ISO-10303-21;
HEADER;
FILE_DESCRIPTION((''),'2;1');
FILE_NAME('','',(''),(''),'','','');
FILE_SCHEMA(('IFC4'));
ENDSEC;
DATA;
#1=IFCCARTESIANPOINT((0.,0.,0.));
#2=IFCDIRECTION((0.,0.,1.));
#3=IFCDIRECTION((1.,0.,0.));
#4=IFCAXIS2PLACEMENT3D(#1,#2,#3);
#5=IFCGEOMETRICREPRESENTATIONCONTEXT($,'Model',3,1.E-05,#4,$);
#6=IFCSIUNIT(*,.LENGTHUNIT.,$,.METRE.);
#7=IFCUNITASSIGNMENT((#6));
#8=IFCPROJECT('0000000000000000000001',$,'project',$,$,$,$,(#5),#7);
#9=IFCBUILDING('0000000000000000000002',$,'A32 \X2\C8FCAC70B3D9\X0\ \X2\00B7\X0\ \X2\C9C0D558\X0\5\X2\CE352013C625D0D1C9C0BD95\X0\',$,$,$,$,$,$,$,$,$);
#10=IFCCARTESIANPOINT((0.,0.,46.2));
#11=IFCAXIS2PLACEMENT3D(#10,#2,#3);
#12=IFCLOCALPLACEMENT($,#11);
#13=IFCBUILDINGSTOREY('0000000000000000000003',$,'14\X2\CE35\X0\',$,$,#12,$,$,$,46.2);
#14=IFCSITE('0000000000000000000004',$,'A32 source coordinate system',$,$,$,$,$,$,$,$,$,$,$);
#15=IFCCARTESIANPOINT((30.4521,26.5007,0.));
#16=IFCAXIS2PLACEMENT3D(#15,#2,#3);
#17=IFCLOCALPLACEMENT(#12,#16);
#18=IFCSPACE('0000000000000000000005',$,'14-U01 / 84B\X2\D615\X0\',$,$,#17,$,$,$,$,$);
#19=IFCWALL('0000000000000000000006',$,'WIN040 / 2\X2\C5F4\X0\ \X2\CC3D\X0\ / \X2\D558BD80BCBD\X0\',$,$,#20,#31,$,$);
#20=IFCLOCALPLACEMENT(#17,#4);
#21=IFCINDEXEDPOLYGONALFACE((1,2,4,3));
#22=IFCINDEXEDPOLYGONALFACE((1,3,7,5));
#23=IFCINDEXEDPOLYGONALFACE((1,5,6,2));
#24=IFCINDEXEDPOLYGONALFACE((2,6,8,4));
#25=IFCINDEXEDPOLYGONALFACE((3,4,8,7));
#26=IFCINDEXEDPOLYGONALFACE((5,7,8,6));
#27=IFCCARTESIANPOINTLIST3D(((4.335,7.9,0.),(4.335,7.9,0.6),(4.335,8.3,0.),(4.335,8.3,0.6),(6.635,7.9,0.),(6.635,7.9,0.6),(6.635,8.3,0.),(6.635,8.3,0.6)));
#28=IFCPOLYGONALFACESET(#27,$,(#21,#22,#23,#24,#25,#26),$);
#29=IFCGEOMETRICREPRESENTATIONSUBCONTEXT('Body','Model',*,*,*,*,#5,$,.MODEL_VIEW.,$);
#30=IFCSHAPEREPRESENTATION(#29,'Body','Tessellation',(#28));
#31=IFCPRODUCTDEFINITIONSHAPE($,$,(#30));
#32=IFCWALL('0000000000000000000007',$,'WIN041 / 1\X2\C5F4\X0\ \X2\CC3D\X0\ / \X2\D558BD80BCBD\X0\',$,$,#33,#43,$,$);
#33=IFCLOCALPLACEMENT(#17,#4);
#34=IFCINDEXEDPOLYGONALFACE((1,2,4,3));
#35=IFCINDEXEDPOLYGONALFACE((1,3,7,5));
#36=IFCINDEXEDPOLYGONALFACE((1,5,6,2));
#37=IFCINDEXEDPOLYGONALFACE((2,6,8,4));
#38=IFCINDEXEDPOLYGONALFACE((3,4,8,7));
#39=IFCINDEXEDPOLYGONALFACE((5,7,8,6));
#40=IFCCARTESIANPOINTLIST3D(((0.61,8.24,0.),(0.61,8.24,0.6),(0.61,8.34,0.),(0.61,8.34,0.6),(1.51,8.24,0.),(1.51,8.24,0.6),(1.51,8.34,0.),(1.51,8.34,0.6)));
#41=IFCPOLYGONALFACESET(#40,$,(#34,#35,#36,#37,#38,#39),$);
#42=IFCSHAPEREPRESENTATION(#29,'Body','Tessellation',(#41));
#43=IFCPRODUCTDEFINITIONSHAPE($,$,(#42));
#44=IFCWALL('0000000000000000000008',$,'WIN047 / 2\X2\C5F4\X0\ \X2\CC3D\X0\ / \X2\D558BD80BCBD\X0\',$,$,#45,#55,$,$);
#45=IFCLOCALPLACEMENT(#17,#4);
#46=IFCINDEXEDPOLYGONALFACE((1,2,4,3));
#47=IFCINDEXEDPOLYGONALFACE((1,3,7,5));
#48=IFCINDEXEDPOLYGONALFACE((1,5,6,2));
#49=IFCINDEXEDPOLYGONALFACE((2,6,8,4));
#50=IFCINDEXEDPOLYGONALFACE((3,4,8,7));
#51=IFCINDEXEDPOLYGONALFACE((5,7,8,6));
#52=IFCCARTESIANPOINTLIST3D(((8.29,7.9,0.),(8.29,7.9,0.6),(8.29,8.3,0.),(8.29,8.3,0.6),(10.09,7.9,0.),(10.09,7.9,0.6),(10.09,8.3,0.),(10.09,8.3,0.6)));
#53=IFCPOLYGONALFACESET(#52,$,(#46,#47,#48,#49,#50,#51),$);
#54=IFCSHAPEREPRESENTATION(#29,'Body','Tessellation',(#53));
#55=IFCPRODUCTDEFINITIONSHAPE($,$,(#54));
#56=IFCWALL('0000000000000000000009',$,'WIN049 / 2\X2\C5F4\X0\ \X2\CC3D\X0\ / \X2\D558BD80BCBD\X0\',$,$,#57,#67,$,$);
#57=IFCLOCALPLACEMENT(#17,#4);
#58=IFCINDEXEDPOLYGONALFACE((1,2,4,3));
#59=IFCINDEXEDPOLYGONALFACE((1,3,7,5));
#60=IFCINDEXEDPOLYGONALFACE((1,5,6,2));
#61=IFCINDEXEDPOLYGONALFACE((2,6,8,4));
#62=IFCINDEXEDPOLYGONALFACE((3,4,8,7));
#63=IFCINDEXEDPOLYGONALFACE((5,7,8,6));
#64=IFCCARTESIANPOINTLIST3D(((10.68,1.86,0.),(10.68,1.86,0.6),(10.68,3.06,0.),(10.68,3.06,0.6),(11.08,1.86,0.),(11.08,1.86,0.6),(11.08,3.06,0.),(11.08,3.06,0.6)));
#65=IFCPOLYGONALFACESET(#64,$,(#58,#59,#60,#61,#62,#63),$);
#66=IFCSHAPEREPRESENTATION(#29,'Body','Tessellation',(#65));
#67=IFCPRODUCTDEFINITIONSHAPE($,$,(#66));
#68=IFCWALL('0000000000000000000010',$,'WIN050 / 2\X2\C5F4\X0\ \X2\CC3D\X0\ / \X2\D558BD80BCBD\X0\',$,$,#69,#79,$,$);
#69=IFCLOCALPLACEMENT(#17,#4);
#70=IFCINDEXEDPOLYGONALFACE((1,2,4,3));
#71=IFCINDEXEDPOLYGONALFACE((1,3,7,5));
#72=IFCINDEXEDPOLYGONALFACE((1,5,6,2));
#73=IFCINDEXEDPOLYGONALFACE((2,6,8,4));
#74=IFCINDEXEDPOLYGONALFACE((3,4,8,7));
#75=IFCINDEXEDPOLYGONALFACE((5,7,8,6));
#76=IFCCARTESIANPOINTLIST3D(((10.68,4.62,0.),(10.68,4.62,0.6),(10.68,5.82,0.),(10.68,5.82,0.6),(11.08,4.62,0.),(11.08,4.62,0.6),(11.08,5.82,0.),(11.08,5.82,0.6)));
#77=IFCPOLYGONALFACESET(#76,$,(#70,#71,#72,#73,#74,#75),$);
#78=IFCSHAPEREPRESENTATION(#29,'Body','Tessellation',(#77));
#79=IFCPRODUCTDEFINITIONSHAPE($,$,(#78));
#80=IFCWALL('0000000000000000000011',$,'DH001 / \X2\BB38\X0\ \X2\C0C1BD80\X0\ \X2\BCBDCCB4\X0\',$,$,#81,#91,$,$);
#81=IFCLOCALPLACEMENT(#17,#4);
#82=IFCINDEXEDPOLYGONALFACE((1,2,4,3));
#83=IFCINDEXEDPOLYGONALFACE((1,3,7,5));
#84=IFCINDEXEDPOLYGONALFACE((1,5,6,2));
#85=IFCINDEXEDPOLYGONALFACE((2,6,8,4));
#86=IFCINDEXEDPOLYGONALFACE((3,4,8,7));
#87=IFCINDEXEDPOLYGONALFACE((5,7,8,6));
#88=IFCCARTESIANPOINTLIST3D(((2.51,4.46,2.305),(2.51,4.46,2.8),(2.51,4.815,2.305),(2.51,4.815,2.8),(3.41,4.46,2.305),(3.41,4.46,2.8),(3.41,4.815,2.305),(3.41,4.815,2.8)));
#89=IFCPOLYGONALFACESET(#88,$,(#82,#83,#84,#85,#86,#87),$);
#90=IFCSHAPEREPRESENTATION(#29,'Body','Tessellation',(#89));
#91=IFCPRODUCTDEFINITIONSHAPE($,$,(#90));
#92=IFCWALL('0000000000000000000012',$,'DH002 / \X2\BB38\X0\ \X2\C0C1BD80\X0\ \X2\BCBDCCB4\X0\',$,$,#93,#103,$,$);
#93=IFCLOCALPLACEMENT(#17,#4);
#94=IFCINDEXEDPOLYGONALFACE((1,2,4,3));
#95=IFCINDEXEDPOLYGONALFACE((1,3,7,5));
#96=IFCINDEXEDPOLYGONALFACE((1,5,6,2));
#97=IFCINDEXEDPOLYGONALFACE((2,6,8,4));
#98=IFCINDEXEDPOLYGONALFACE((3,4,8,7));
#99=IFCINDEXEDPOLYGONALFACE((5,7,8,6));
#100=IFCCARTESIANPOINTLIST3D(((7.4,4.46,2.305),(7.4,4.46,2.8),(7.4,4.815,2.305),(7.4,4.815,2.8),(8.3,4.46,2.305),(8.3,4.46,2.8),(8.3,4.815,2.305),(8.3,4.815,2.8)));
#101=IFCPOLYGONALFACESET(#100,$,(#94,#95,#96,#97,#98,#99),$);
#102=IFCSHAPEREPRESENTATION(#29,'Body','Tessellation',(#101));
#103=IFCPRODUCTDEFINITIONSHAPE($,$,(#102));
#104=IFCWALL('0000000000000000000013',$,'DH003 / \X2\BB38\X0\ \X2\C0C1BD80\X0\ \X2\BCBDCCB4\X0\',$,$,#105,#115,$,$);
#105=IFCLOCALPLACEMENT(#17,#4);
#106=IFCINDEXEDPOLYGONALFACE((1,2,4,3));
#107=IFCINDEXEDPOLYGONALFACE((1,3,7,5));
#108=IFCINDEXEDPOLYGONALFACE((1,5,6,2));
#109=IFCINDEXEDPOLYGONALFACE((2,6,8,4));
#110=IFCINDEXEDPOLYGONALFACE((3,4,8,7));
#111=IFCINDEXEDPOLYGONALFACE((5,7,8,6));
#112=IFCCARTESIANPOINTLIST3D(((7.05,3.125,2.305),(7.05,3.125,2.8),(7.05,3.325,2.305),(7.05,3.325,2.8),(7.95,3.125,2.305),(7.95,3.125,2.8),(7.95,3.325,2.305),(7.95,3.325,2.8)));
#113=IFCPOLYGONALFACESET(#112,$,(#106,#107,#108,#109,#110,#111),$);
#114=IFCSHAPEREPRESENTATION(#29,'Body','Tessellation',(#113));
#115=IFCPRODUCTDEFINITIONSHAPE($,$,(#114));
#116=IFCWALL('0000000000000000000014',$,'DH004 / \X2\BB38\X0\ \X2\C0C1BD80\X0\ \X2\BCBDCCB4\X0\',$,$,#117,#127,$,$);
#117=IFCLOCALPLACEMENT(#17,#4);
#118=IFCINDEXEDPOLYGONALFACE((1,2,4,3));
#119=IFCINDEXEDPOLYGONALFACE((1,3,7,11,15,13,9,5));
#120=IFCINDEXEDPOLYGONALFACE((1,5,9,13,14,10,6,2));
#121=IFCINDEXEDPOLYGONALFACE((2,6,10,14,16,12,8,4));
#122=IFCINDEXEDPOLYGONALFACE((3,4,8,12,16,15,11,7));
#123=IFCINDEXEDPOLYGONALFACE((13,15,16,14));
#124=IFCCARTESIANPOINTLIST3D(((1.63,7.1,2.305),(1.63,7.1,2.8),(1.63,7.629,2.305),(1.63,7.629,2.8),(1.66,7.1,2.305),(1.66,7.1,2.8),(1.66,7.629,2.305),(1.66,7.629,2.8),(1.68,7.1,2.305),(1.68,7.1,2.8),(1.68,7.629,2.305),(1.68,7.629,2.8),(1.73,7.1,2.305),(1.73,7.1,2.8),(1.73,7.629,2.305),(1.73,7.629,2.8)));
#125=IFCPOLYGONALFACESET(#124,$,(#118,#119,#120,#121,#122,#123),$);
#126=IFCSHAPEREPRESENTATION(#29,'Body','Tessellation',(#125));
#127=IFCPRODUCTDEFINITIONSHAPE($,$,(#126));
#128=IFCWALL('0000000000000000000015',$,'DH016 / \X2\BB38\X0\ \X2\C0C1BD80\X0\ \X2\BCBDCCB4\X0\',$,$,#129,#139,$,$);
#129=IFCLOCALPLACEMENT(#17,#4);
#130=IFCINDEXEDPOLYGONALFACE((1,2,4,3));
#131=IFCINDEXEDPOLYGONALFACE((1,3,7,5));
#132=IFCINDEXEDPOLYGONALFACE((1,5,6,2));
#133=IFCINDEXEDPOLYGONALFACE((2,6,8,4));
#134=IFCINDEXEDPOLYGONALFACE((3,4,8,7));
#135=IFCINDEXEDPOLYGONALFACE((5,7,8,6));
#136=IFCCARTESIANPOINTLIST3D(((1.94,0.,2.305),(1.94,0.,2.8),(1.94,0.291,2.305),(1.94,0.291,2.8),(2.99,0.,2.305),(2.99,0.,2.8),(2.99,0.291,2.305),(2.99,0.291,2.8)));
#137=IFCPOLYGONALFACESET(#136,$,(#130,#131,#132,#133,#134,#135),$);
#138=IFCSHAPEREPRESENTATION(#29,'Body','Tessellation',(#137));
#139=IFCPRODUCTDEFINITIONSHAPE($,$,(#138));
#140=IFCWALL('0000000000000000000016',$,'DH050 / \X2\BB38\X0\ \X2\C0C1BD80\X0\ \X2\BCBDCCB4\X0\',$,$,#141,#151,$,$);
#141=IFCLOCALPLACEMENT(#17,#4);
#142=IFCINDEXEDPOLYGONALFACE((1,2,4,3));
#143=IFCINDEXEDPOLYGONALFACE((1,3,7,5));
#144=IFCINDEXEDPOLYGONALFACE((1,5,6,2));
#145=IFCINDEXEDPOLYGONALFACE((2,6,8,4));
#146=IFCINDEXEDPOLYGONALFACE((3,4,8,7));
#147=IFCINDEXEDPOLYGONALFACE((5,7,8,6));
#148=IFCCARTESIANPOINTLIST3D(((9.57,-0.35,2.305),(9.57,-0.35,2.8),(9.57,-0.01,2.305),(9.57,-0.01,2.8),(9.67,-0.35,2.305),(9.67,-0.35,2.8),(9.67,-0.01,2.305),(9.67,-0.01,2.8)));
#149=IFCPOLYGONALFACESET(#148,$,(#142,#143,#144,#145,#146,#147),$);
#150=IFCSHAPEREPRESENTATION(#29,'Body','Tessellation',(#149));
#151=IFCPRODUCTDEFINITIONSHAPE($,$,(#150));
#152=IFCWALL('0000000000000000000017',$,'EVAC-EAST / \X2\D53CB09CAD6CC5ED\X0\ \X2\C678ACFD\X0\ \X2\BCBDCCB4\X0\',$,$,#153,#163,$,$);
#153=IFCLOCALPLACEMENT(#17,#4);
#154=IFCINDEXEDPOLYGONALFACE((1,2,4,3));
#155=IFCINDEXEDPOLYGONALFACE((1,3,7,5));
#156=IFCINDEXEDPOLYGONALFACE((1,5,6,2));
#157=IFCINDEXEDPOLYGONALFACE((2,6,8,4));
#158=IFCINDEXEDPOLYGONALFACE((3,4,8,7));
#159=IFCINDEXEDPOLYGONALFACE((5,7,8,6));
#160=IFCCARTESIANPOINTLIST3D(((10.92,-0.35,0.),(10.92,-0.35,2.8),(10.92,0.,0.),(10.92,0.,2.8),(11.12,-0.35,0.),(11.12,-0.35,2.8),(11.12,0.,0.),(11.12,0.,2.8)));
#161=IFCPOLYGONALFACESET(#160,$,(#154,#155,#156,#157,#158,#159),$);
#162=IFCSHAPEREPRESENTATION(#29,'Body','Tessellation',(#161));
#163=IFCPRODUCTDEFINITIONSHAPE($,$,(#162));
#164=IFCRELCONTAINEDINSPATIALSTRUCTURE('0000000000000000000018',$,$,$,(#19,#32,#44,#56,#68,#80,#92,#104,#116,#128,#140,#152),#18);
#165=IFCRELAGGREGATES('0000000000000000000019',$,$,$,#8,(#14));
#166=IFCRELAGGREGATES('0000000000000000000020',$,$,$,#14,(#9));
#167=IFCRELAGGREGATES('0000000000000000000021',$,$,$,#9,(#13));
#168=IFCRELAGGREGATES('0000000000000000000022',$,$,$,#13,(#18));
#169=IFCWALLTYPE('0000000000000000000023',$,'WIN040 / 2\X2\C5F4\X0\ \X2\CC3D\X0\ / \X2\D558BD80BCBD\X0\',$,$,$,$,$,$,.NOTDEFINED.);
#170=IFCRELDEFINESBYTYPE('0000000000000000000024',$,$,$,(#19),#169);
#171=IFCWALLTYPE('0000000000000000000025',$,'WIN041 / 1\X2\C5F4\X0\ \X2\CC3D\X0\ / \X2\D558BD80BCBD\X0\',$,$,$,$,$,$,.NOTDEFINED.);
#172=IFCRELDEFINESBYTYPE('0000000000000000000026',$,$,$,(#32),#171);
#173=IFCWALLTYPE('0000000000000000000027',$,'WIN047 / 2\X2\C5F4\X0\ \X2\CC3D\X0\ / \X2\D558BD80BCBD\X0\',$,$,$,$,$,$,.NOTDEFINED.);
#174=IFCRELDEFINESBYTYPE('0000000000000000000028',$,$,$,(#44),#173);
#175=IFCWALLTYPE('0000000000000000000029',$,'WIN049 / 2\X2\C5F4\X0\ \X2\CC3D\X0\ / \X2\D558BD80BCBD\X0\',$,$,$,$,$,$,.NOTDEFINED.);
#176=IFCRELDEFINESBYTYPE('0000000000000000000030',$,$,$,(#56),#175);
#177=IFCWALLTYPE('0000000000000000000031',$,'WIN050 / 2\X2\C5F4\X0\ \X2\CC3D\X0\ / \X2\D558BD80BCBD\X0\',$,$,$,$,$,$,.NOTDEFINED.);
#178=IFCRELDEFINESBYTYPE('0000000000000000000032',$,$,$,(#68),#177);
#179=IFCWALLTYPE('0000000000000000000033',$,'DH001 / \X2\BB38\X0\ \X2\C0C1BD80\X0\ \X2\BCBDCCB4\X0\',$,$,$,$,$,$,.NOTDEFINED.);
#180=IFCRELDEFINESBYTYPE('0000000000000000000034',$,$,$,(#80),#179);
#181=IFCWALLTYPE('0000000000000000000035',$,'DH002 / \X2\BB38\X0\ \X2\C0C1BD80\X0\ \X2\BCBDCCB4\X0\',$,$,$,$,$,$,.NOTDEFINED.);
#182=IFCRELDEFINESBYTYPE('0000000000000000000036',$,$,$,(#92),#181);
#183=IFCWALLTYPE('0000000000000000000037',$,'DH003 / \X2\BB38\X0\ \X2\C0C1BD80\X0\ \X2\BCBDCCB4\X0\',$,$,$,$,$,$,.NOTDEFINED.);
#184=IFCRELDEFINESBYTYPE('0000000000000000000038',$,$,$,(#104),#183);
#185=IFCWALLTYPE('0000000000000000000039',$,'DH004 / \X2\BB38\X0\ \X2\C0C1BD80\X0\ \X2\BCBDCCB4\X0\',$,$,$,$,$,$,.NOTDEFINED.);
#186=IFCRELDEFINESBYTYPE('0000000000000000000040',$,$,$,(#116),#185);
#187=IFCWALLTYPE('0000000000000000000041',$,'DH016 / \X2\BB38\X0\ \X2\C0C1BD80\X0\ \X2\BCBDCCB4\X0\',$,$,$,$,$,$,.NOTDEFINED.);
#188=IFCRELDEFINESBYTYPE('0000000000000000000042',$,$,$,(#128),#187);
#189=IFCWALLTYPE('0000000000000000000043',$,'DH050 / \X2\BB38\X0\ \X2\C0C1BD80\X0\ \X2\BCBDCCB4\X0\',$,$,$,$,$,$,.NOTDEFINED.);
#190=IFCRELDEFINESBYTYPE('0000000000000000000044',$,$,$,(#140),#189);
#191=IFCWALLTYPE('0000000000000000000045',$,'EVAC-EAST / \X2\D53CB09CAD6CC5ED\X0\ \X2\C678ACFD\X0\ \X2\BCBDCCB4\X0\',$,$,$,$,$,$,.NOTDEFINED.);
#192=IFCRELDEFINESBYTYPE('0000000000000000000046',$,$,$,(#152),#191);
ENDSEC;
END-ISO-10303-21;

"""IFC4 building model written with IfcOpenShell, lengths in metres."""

from ifc_helpers import new_model, si_unit, frame, origin, origin_with_axes, place, context, subcontext, project, spatial, polyline, outline, extrude, source, transform, mapped, type_object, type_shapes, element, save


model = new_model("IFC4")

# Units and contexts
model_context = context("Model", 3, precision=1e-05, world=origin_with_axes())
body_context = subcontext(model_context, "Body", "Model", "MODEL_VIEW")
ifc_project = project(units=[si_unit("LENGTHUNIT", "METRE")], contexts=[model_context])

# Site, building, storey, space
site = spatial("IfcSite", under=ifc_project, Name="A32 source coordinate system")
building = spatial("IfcBuilding", under=site, Name="A32 주거동 · 지하5층–옥탑지붕")
storey_placement = place(None, frame((0.0, 0.0, 46.2), z_axis=(0.0, 0.0, 1.0), x_axis=(1.0, 0.0, 0.0)))
storey = spatial("IfcBuildingStorey", under=building, at=storey_placement, Name="14층", Elevation=46.2)
space_placement = place(storey_placement, frame((30.4521, 26.5007, 0.0), z_axis=(0.0, 0.0, 1.0), x_axis=(1.0, 0.0, 0.0)))
space = spatial("IfcSpace", under=storey, at=space_placement, Name="14-U01 / 84B형")

# Walls
wall_type_1 = type_object("IfcWallType", Name="WIN040 / 2열 창 / 하부벽", PredefinedType="NOTDEFINED")
shared_shape_1 = source(origin(), body_context, "Body", "SweptSolid", [
    extrude(outline(polyline([(4.335, 8.3), (6.635, 8.3), (6.635, 7.9), (4.335, 7.9), (4.335, 8.3)])), origin(), (0.0, 0.0, 1.0), 0.6),
])
type_shapes(wall_type_1, [shared_shape_1])
wall_1_placement = place(space_placement, origin_with_axes())
element("IfcWall", 1, at=wall_1_placement, inside=space, type_object=wall_type_1, Name="WIN040 / 2열 창 / 하부벽", context=body_context, shape_type="MappedRepresentation", body=[
    mapped(shared_shape_1, transform((0.0, 0.0, 0.0), scale=1.0)),
])
wall_type_2 = type_object("IfcWallType", Name="WIN041 / 1열 창 / 하부벽", PredefinedType="NOTDEFINED")
shared_shape_2 = source(origin(), body_context, "Body", "SweptSolid", [
    extrude(outline(polyline([(0.61, 8.34), (1.51, 8.34), (1.51, 8.24), (0.61, 8.24), (0.61, 8.34)])), origin(), (0.0, 0.0, 1.0), 0.6),
])
type_shapes(wall_type_2, [shared_shape_2])
wall_2_placement = place(space_placement, origin_with_axes())
element("IfcWall", 2, at=wall_2_placement, inside=space, type_object=wall_type_2, Name="WIN041 / 1열 창 / 하부벽", context=body_context, shape_type="MappedRepresentation", body=[
    mapped(shared_shape_2, transform((0.0, 0.0, 0.0), scale=1.0)),
])
wall_type_3 = type_object("IfcWallType", Name="WIN047 / 2열 창 / 하부벽", PredefinedType="NOTDEFINED")
shared_shape_3 = source(origin(), body_context, "Body", "SweptSolid", [
    extrude(outline(polyline([(8.29, 8.3), (10.09, 8.3), (10.09, 7.9), (8.29, 7.9), (8.29, 8.3)])), origin(), (0.0, 0.0, 1.0), 0.6),
])
type_shapes(wall_type_3, [shared_shape_3])
wall_3_placement = place(space_placement, origin_with_axes())
element("IfcWall", 3, at=wall_3_placement, inside=space, type_object=wall_type_3, Name="WIN047 / 2열 창 / 하부벽", context=body_context, shape_type="MappedRepresentation", body=[
    mapped(shared_shape_3, transform((0.0, 0.0, 0.0), scale=1.0)),
])
wall_type_4 = type_object("IfcWallType", Name="WIN049 / 2열 창 / 하부벽", PredefinedType="NOTDEFINED")
shared_shape_4 = source(origin(), body_context, "Body", "SweptSolid", [
    extrude(outline(polyline([(10.68, 3.06), (11.08, 3.06), (11.08, 1.86), (10.68, 1.86), (10.68, 3.06)])), origin(), (0.0, 0.0, 1.0), 0.6),
])
type_shapes(wall_type_4, [shared_shape_4])
wall_4_placement = place(space_placement, origin_with_axes())
element("IfcWall", 4, at=wall_4_placement, inside=space, type_object=wall_type_4, Name="WIN049 / 2열 창 / 하부벽", context=body_context, shape_type="MappedRepresentation", body=[
    mapped(shared_shape_4, transform((0.0, 0.0, 0.0), scale=1.0)),
])
wall_type_5 = type_object("IfcWallType", Name="WIN050 / 2열 창 / 하부벽", PredefinedType="NOTDEFINED")
shared_shape_5 = source(origin(), body_context, "Body", "SweptSolid", [
    extrude(outline(polyline([(10.68, 5.82), (11.08, 5.82), (11.08, 4.62), (10.68, 4.62), (10.68, 5.82)])), origin(), (0.0, 0.0, 1.0), 0.6),
])
type_shapes(wall_type_5, [shared_shape_5])
wall_5_placement = place(space_placement, origin_with_axes())
element("IfcWall", 5, at=wall_5_placement, inside=space, type_object=wall_type_5, Name="WIN050 / 2열 창 / 하부벽", context=body_context, shape_type="MappedRepresentation", body=[
    mapped(shared_shape_5, transform((0.0, 0.0, 0.0), scale=1.0)),
])
wall_type_6 = type_object("IfcWallType", Name="DH001 / 문 상부 벽체", PredefinedType="NOTDEFINED")
shared_shape_6 = source(origin(), body_context, "Body", "SweptSolid", [
    extrude(outline(polyline([(3.41, 4.815), (3.41, 4.46), (2.51, 4.46), (2.51, 4.815), (3.41, 4.815)])), frame((0.0, 0.0, 2.305)), (0.0, 0.0, 1.0), 0.495),
])
type_shapes(wall_type_6, [shared_shape_6])
wall_6_placement = place(space_placement, origin_with_axes())
element("IfcWall", 6, at=wall_6_placement, inside=space, type_object=wall_type_6, Name="DH001 / 문 상부 벽체", context=body_context, shape_type="MappedRepresentation", body=[
    mapped(shared_shape_6, transform((0.0, 0.0, 0.0), scale=1.0)),
])
wall_type_7 = type_object("IfcWallType", Name="DH002 / 문 상부 벽체", PredefinedType="NOTDEFINED")
shared_shape_7 = source(origin(), body_context, "Body", "SweptSolid", [
    extrude(outline(polyline([(8.3, 4.815), (8.3, 4.46), (7.4, 4.46), (7.4, 4.815), (8.3, 4.815)])), frame((0.0, 0.0, 2.305)), (0.0, 0.0, 1.0), 0.495),
])
type_shapes(wall_type_7, [shared_shape_7])
wall_7_placement = place(space_placement, origin_with_axes())
element("IfcWall", 7, at=wall_7_placement, inside=space, type_object=wall_type_7, Name="DH002 / 문 상부 벽체", context=body_context, shape_type="MappedRepresentation", body=[
    mapped(shared_shape_7, transform((0.0, 0.0, 0.0), scale=1.0)),
])
wall_type_8 = type_object("IfcWallType", Name="DH003 / 문 상부 벽체", PredefinedType="NOTDEFINED")
shared_shape_8 = source(origin(), body_context, "Body", "SweptSolid", [
    extrude(outline(polyline([(7.95, 3.325), (7.95, 3.125), (7.05, 3.125), (7.05, 3.325), (7.95, 3.325)])), frame((0.0, 0.0, 2.305)), (0.0, 0.0, 1.0), 0.495),
])
type_shapes(wall_type_8, [shared_shape_8])
wall_8_placement = place(space_placement, origin_with_axes())
element("IfcWall", 8, at=wall_8_placement, inside=space, type_object=wall_type_8, Name="DH003 / 문 상부 벽체", context=body_context, shape_type="MappedRepresentation", body=[
    mapped(shared_shape_8, transform((0.0, 0.0, 0.0), scale=1.0)),
])
wall_type_9 = type_object("IfcWallType", Name="DH004 / 문 상부 벽체", PredefinedType="NOTDEFINED")
shared_shape_9 = source(origin(), body_context, "Body", "SweptSolid", [
    extrude(outline(polyline([(1.66, 7.1), (1.63, 7.1), (1.63, 7.629), (1.66, 7.629), (1.68, 7.629), (1.73, 7.629), (1.73, 7.1), (1.68, 7.1), (1.66, 7.1)])), frame((0.0, 0.0, 2.305)), (0.0, 0.0, 1.0), 0.495),
])
type_shapes(wall_type_9, [shared_shape_9])
wall_9_placement = place(space_placement, origin_with_axes())
element("IfcWall", 9, at=wall_9_placement, inside=space, type_object=wall_type_9, Name="DH004 / 문 상부 벽체", context=body_context, shape_type="MappedRepresentation", body=[
    mapped(shared_shape_9, transform((0.0, 0.0, 0.0), scale=1.0)),
])
wall_type_10 = type_object("IfcWallType", Name="DH016 / 문 상부 벽체", PredefinedType="NOTDEFINED")
shared_shape_10 = source(origin(), body_context, "Body", "SweptSolid", [
    extrude(outline(polyline([(2.99, 0.291), (2.99, 0.0), (1.94, 0.0), (1.94, 0.291), (2.99, 0.291)])), frame((0.0, 0.0, 2.305)), (0.0, 0.0, 1.0), 0.495),
])
type_shapes(wall_type_10, [shared_shape_10])
wall_10_placement = place(space_placement, origin_with_axes())
element("IfcWall", 10, at=wall_10_placement, inside=space, type_object=wall_type_10, Name="DH016 / 문 상부 벽체", context=body_context, shape_type="MappedRepresentation", body=[
    mapped(shared_shape_10, transform((0.0, 0.0, 0.0), scale=1.0)),
])
wall_type_11 = type_object("IfcWallType", Name="DH050 / 문 상부 벽체", PredefinedType="NOTDEFINED")
shared_shape_11 = source(origin(), body_context, "Body", "SweptSolid", [
    extrude(outline(polyline([(9.67, -0.01), (9.67, -0.35), (9.57, -0.35), (9.57, -0.01), (9.67, -0.01)])), frame((0.0, 0.0, 2.305)), (0.0, 0.0, 1.0), 0.495),
])
type_shapes(wall_type_11, [shared_shape_11])
wall_11_placement = place(space_placement, origin_with_axes())
element("IfcWall", 11, at=wall_11_placement, inside=space, type_object=wall_type_11, Name="DH050 / 문 상부 벽체", context=body_context, shape_type="MappedRepresentation", body=[
    mapped(shared_shape_11, transform((0.0, 0.0, 0.0), scale=1.0)),
])
wall_type_12 = type_object("IfcWallType", Name="EVAC-EAST / 피난구역 외곽 벽체", PredefinedType="NOTDEFINED")
shared_shape_12 = source(origin(), body_context, "Body", "SweptSolid", [
    extrude(outline(polyline([(10.92, 0.0), (11.12, 0.0), (11.12, -0.35), (10.92, -0.35), (10.92, 0.0)])), origin(), (0.0, 0.0, 1.0), 2.8),
])
type_shapes(wall_type_12, [shared_shape_12])
wall_12_placement = place(space_placement, origin_with_axes())
element("IfcWall", 12, at=wall_12_placement, inside=space, type_object=wall_type_12, Name="EVAC-EAST / 피난구역 외곽 벽체", context=body_context, shape_type="MappedRepresentation", body=[
    mapped(shared_shape_12, transform((0.0, 0.0, 0.0), scale=1.0)),
])

save(model, "model.ifc")
